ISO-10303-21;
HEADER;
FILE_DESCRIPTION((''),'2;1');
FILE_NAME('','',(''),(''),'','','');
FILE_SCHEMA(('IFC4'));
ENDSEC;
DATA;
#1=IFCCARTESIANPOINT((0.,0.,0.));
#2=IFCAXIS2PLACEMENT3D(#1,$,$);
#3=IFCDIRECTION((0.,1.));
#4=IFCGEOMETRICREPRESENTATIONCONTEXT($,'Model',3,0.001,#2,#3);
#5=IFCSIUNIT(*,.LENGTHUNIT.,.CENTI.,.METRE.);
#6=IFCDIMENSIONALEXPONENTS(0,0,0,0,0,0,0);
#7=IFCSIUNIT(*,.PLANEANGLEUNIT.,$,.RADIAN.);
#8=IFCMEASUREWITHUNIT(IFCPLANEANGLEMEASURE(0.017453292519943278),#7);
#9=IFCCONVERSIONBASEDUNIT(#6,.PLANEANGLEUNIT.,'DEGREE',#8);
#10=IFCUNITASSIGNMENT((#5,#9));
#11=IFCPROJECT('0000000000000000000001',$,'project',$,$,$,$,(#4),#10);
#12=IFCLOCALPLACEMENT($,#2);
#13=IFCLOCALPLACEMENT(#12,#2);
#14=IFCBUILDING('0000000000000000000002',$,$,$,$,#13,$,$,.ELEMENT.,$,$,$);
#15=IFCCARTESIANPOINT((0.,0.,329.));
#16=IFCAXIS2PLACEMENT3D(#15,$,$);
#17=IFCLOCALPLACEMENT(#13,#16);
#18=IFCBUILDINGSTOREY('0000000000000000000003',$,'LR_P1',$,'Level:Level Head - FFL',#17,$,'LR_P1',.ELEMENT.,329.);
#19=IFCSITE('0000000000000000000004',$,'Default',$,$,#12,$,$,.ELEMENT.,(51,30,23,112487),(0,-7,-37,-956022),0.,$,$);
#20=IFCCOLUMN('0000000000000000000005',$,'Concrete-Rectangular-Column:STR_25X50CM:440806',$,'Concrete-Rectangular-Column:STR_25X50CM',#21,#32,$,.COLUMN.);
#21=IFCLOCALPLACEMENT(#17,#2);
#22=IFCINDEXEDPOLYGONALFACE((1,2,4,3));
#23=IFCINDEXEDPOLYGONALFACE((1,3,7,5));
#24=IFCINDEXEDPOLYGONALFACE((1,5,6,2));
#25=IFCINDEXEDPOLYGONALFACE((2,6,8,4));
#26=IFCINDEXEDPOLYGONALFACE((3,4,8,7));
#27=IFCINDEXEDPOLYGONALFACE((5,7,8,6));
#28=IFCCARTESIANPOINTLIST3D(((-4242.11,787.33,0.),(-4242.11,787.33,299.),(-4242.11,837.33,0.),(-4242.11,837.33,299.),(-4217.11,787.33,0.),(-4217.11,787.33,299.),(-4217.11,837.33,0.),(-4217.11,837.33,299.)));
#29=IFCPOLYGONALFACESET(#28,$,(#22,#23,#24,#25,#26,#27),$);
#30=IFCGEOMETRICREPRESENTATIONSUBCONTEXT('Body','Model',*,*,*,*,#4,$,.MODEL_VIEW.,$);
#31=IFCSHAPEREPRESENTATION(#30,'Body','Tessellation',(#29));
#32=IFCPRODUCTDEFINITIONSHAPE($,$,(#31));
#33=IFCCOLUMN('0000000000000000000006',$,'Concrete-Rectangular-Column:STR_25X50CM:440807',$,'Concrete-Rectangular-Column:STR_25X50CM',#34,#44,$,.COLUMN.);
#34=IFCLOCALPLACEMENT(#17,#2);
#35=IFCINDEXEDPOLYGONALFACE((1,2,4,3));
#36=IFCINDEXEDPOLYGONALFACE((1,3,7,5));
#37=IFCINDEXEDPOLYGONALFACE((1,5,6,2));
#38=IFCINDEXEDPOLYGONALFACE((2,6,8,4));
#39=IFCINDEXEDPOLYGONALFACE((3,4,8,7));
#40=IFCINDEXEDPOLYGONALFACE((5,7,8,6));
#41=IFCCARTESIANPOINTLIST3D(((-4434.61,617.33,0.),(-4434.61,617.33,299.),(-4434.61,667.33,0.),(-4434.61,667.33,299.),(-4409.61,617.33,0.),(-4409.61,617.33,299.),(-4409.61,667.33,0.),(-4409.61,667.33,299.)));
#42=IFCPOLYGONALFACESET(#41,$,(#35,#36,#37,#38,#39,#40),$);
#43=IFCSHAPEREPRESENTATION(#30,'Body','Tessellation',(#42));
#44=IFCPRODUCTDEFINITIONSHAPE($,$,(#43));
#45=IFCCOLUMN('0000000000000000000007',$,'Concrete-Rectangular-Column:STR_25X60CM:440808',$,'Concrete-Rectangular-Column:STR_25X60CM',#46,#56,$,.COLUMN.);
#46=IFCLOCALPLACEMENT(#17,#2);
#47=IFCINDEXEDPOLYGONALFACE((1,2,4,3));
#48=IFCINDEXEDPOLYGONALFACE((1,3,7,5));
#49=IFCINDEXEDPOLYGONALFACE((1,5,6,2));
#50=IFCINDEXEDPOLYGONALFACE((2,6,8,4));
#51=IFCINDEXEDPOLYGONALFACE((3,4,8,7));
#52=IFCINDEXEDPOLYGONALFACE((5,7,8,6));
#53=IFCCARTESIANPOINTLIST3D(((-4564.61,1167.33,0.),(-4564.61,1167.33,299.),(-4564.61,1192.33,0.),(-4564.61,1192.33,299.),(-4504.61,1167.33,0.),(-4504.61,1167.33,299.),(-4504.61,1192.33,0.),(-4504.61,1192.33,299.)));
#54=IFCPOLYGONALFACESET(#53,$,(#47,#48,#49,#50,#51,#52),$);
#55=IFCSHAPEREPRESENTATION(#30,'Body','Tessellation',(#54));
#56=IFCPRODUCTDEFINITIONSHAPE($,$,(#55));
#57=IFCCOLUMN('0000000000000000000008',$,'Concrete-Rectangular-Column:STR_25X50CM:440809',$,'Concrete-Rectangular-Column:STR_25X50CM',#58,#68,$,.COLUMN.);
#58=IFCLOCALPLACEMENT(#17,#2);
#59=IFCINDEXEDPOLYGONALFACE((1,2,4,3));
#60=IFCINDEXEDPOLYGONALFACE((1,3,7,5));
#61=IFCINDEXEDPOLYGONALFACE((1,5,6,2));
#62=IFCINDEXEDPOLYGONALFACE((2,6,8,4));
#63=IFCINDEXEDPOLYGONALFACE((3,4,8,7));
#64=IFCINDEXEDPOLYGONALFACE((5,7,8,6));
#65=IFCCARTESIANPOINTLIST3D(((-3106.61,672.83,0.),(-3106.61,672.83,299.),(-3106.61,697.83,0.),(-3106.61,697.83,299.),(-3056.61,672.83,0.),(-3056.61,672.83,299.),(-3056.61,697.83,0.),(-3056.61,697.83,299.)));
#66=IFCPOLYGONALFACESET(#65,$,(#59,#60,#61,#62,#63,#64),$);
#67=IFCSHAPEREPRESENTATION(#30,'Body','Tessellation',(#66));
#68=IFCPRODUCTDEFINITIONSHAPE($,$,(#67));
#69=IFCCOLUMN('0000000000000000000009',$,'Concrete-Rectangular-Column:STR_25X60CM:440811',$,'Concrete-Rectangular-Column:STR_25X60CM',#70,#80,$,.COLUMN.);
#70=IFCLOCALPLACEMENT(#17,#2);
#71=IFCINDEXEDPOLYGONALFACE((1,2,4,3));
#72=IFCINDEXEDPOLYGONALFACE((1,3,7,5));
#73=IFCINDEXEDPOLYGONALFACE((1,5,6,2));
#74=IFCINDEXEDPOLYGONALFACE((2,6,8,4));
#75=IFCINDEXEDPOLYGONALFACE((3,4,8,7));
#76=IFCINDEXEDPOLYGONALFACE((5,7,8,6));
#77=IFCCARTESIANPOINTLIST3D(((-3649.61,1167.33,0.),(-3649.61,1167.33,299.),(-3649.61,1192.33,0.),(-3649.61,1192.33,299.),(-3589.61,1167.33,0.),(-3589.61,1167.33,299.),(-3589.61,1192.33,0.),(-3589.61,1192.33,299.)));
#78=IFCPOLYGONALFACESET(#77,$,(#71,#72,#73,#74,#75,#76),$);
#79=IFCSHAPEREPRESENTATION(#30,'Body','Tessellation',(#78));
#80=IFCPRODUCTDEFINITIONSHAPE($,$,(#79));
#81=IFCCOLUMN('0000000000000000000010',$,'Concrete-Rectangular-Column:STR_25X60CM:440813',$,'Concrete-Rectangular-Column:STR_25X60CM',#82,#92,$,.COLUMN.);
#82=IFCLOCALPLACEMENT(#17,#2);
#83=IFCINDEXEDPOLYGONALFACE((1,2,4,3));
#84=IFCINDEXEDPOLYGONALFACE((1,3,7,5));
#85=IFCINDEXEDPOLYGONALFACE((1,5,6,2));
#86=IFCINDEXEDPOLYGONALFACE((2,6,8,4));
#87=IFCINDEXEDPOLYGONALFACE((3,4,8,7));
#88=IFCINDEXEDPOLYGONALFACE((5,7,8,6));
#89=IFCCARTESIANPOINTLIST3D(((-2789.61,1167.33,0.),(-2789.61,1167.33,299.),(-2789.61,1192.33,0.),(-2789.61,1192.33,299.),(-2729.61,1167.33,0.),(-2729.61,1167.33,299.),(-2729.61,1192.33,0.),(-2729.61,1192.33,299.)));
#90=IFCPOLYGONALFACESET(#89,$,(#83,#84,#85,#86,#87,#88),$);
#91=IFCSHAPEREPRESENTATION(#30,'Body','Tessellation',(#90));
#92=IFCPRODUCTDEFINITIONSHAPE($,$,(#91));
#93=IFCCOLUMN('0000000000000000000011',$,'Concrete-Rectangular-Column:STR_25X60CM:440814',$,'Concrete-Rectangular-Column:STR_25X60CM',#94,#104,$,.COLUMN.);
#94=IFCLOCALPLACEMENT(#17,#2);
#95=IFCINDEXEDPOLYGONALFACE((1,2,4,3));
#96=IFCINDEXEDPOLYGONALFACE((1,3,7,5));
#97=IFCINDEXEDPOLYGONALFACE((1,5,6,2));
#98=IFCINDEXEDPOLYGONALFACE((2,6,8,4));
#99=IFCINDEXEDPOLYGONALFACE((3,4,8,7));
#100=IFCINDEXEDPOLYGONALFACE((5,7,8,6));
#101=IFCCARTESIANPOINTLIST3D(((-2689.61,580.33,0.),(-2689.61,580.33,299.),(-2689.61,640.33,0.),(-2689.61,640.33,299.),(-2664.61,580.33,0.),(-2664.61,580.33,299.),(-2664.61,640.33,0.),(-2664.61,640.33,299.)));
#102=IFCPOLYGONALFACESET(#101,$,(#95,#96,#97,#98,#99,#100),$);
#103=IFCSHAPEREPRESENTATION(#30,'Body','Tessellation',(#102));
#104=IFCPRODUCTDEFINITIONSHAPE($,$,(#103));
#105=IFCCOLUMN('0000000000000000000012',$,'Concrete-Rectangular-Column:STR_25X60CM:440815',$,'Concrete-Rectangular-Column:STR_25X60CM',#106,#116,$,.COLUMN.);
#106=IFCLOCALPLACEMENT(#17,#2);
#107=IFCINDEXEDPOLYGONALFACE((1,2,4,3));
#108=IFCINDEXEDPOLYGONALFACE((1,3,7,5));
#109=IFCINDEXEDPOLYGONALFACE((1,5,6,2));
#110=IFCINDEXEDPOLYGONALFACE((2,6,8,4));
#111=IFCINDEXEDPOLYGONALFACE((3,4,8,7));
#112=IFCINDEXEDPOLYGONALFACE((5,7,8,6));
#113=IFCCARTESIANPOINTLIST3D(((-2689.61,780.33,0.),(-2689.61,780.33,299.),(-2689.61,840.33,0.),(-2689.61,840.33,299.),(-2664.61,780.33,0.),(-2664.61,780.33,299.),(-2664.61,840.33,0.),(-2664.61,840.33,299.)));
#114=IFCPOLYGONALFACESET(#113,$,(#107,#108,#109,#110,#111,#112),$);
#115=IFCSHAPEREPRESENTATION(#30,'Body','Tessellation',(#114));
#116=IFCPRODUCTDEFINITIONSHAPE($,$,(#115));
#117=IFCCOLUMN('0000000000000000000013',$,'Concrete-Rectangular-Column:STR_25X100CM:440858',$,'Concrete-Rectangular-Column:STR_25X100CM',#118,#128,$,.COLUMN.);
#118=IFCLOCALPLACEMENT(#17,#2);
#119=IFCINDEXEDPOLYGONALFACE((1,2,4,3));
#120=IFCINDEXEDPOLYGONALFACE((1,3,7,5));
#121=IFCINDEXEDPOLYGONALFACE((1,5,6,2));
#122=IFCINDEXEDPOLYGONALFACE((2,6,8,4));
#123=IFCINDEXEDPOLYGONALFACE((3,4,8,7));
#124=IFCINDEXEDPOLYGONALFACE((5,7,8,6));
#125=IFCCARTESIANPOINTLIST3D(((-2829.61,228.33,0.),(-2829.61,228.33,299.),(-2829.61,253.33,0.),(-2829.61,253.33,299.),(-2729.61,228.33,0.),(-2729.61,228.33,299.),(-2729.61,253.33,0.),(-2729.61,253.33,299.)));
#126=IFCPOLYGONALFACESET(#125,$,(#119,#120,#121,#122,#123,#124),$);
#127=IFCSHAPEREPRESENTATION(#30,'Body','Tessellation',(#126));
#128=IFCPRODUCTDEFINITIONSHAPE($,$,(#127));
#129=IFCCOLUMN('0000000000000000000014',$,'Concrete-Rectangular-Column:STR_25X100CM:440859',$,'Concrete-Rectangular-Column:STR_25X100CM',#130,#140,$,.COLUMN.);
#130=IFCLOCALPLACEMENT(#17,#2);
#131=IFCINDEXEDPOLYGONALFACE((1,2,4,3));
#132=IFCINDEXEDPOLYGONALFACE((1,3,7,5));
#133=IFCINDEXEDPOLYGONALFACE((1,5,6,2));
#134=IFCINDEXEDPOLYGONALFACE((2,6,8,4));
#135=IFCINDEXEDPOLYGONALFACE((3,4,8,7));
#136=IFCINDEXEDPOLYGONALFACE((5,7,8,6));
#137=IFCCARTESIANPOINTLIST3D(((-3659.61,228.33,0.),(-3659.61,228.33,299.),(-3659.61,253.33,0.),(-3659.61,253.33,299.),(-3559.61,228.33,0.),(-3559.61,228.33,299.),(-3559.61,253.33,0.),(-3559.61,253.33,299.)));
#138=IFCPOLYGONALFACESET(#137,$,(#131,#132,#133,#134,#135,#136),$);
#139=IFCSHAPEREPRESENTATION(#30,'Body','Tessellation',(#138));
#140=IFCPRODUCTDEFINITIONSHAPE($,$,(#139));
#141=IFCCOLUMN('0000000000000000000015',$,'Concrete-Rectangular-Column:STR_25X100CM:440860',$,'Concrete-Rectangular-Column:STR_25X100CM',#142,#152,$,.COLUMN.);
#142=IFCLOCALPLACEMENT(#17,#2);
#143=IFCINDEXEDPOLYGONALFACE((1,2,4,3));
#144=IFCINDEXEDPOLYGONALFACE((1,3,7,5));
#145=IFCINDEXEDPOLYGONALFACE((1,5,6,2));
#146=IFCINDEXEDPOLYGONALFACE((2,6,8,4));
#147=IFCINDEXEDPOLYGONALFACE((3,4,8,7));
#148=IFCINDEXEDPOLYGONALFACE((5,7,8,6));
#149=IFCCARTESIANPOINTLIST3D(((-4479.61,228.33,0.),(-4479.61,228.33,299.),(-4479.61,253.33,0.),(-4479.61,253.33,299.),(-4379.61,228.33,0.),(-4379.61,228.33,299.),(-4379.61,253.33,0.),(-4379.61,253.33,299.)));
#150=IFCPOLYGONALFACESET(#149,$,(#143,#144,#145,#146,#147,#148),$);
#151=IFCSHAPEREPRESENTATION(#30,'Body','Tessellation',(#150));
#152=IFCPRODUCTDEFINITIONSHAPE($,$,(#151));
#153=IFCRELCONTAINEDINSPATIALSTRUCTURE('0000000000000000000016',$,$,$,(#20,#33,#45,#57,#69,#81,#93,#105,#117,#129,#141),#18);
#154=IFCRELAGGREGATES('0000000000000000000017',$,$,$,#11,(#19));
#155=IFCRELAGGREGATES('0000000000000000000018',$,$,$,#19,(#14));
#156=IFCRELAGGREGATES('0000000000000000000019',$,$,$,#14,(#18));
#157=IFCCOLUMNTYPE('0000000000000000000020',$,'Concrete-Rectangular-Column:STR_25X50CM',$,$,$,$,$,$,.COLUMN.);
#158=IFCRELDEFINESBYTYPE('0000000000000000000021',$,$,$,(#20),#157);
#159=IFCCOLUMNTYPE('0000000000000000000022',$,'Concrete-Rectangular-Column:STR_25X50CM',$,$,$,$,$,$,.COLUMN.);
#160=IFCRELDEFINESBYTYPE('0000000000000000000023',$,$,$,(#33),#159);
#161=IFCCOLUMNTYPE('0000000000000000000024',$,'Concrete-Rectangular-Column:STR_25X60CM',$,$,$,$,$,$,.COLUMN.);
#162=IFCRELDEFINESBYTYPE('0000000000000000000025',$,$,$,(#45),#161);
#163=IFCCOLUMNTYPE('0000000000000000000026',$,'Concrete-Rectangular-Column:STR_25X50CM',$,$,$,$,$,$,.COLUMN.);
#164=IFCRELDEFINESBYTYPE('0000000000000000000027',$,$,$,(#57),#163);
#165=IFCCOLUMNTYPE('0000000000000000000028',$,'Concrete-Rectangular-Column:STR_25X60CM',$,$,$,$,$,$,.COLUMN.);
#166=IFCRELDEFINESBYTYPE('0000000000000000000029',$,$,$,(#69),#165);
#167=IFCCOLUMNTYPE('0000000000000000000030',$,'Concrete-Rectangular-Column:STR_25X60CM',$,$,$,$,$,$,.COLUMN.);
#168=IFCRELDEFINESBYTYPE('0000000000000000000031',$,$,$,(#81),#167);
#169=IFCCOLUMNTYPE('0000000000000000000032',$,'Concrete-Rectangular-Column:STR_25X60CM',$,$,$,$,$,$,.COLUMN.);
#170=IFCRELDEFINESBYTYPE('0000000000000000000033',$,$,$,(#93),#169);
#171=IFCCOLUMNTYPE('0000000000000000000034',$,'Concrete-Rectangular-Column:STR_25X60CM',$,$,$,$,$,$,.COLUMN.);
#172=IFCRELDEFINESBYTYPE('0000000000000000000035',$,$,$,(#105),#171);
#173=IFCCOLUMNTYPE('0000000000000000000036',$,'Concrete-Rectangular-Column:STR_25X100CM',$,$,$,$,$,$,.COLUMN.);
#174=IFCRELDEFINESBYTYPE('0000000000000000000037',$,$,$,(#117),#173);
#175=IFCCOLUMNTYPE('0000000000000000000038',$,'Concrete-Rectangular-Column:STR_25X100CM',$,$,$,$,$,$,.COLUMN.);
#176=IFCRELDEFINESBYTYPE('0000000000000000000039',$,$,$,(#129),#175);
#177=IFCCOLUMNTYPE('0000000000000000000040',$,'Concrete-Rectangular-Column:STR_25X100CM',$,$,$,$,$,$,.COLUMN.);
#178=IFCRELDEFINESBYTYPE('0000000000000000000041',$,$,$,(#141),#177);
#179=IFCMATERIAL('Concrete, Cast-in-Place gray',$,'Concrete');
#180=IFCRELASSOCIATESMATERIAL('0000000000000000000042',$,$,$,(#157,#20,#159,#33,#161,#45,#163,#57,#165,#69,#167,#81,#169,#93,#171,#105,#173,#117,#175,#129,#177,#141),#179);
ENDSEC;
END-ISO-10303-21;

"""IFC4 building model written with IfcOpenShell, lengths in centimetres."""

from ifc_helpers import new_model, entity, si_unit, converted_unit, direction, frame, origin, place, context, subcontext, project, spatial, indexed_curve, outline, extrude, source, transform, mapped, material, type_object, type_shapes, element, save


model = new_model("IFC4")

# Units and contexts
model_context = context("Model", 3, precision=0.001, world=origin(), true_north=direction((0.0, 1.0)))
body_context = subcontext(model_context, "Body", "Model", "MODEL_VIEW")
ifc_project = project(units=[si_unit("LENGTHUNIT", "METRE", prefix="CENTI"), converted_unit("PLANEANGLEUNIT", "DEGREE", entity("IfcPlaneAngleMeasure", 0.017453292519943278), si_unit("PLANEANGLEUNIT", "RADIAN"), dimensions=[0, 0, 0, 0, 0, 0, 0])], contexts=[model_context])

# Site, building, storey
site_placement = place(None, origin())
site = spatial("IfcSite", under=ifc_project, at=site_placement, Name="Default", CompositionType="ELEMENT", RefLatitude=(51, 30, 23, 112487), RefLongitude=(0, -7, -37, -956022), RefElevation=0.0)
building_placement = place(site_placement, origin())
building = spatial("IfcBuilding", under=site, at=building_placement, CompositionType="ELEMENT")
storey_placement = place(building_placement, frame((0.0, 0.0, 329.0)))
storey = spatial("IfcBuildingStorey", under=building, at=storey_placement, Name="LR_P1", ObjectType="Level:Level Head - FFL", LongName="LR_P1", CompositionType="ELEMENT", Elevation=329.0)

# Columns
ifc_material_1 = material(Name="Concrete, Cast-in-Place gray", Category="Concrete")
column_type_1 = type_object("IfcColumnType", Name="Concrete-Rectangular-Column:STR_25X50CM", PredefinedType="COLUMN", material=ifc_material_1)
shared_shape_1 = source(origin(), body_context, "Body", "SweptSolid", [
    extrude(outline(indexed_curve([(-12.5, -25.0), (12.5, -25.0), (12.5, 25.0), (-12.5, 25.0), (-12.5, -25.0)], self_intersect=False)), frame((-4229.61, 812.33, 329.0), z_axis=(0.0, 0.0, 1.0), x_axis=(-1.0, 0.0, 0.0)), (0.0, 0.0, 1.0), 299.0),
])
type_shapes(column_type_1, [shared_shape_1])
column_1_placement = place(storey_placement, frame((0.0, 0.0, -329.0)))
element("IfcColumn", 1, at=column_1_placement, inside=storey, type_object=column_type_1, material=ifc_material_1, Name="Concrete-Rectangular-Column:STR_25X50CM:440806", ObjectType="Concrete-Rectangular-Column:STR_25X50CM", PredefinedType="COLUMN", context=body_context, shape_type="MappedRepresentation", body=[
    mapped(shared_shape_1, transform((0.0, 0.0, 0.0), scale=1.0)),
])
column_type_2 = type_object("IfcColumnType", Name="Concrete-Rectangular-Column:STR_25X50CM", PredefinedType="COLUMN", material=ifc_material_1)
shared_shape_2 = source(origin(), body_context, "Body", "SweptSolid", [
    extrude(outline(indexed_curve([(-12.5, -25.0), (12.5, -25.0), (12.5, 25.0), (-12.5, 25.0), (-12.5, -25.0)], self_intersect=False)), frame((-4422.11, 642.33, 329.0), z_axis=(0.0, 0.0, 1.0), x_axis=(-1.0, 0.0, 0.0)), (0.0, 0.0, 1.0), 299.0),
])
type_shapes(column_type_2, [shared_shape_2])
column_2_placement = place(storey_placement, frame((0.0, 0.0, -329.0)))
element("IfcColumn", 2, at=column_2_placement, inside=storey, type_object=column_type_2, material=ifc_material_1, Name="Concrete-Rectangular-Column:STR_25X50CM:440807", ObjectType="Concrete-Rectangular-Column:STR_25X50CM", PredefinedType="COLUMN", context=body_context, shape_type="MappedRepresentation", body=[
    mapped(shared_shape_2, transform((0.0, 0.0, 0.0), scale=1.0)),
])
column_type_3 = type_object("IfcColumnType", Name="Concrete-Rectangular-Column:STR_25X60CM", PredefinedType="COLUMN", material=ifc_material_1)
shared_shape_3 = source(origin(), body_context, "Body", "SweptSolid", [
    extrude(outline(indexed_curve([(-12.5, -30.0), (12.5, -30.0), (12.5, 30.0), (-12.5, 30.0), (-12.5, -30.0)], self_intersect=False)), frame((-4534.61, 1179.83, 329.0), z_axis=(0.0, 0.0, 1.0), x_axis=(0.0, -1.0, 0.0)), (0.0, 0.0, 1.0), 299.0),
])
type_shapes(column_type_3, [shared_shape_3])
column_3_placement = place(storey_placement, frame((0.0, 0.0, -329.0)))
element("IfcColumn", 3, at=column_3_placement, inside=storey, type_object=column_type_3, material=ifc_material_1, Name="Concrete-Rectangular-Column:STR_25X60CM:440808", ObjectType="Concrete-Rectangular-Column:STR_25X60CM", PredefinedType="COLUMN", context=body_context, shape_type="MappedRepresentation", body=[
    mapped(shared_shape_3, transform((0.0, 0.0, 0.0), scale=1.0)),
])
column_type_4 = type_object("IfcColumnType", Name="Concrete-Rectangular-Column:STR_25X50CM", PredefinedType="COLUMN", material=ifc_material_1)
shared_shape_4 = source(origin(), body_context, "Body", "SweptSolid", [
    extrude(outline(indexed_curve([(-12.5, -25.0), (12.5, -25.0), (12.5, 25.0), (-12.5, 25.0), (-12.5, -25.0)], self_intersect=False)), frame((-3081.61, 685.33, 329.0), z_axis=(0.0, 0.0, 1.0), x_axis=(0.0, -1.0, 0.0)), (0.0, 0.0, 1.0), 299.0),
])
type_shapes(column_type_4, [shared_shape_4])
column_4_placement = place(storey_placement, frame((0.0, 0.0, -329.0)))
element("IfcColumn", 4, at=column_4_placement, inside=storey, type_object=column_type_4, material=ifc_material_1, Name="Concrete-Rectangular-Column:STR_25X50CM:440809", ObjectType="Concrete-Rectangular-Column:STR_25X50CM", PredefinedType="COLUMN", context=body_context, shape_type="MappedRepresentation", body=[
    mapped(shared_shape_4, transform((0.0, 0.0, 0.0), scale=1.0)),
])
column_type_5 = type_object("IfcColumnType", Name="Concrete-Rectangular-Column:STR_25X60CM", PredefinedType="COLUMN", material=ifc_material_1)
shared_shape_5 = source(origin(), body_context, "Body", "SweptSolid", [
    extrude(outline(indexed_curve([(-12.5, -30.0), (12.5, -30.0), (12.5, 30.0), (-12.5, 30.0), (-12.5, -30.0)], self_intersect=False)), frame((-3619.61, 1179.83, 329.0), z_axis=(0.0, 0.0, 1.0), x_axis=(0.0, -1.0, 0.0)), (0.0, 0.0, 1.0), 299.0),
])
type_shapes(column_type_5, [shared_shape_5])
column_5_placement = place(storey_placement, frame((0.0, 0.0, -329.0)))
element("IfcColumn", 5, at=column_5_placement, inside=storey, type_object=column_type_5, material=ifc_material_1, Name="Concrete-Rectangular-Column:STR_25X60CM:440811", ObjectType="Concrete-Rectangular-Column:STR_25X60CM", PredefinedType="COLUMN", context=body_context, shape_type="MappedRepresentation", body=[
    mapped(shared_shape_5, transform((0.0, 0.0, 0.0), scale=1.0)),
])
column_type_6 = type_object("IfcColumnType", Name="Concrete-Rectangular-Column:STR_25X60CM", PredefinedType="COLUMN", material=ifc_material_1)
shared_shape_6 = source(origin(), body_context, "Body", "SweptSolid", [
    extrude(outline(indexed_curve([(-12.5, -30.0), (12.5, -30.0), (12.5, 30.0), (-12.5, 30.0), (-12.5, -30.0)], self_intersect=False)), frame((-2759.61, 1179.83, 329.0), z_axis=(0.0, 0.0, 1.0), x_axis=(0.0, -1.0, 0.0)), (0.0, 0.0, 1.0), 299.0),
])
type_shapes(column_type_6, [shared_shape_6])
column_6_placement = place(storey_placement, frame((0.0, 0.0, -329.0)))
element("IfcColumn", 6, at=column_6_placement, inside=storey, type_object=column_type_6, material=ifc_material_1, Name="Concrete-Rectangular-Column:STR_25X60CM:440813", ObjectType="Concrete-Rectangular-Column:STR_25X60CM", PredefinedType="COLUMN", context=body_context, shape_type="MappedRepresentation", body=[
    mapped(shared_shape_6, transform((0.0, 0.0, 0.0), scale=1.0)),
])
column_type_7 = type_object("IfcColumnType", Name="Concrete-Rectangular-Column:STR_25X60CM", PredefinedType="COLUMN", material=ifc_material_1)
shared_shape_7 = source(origin(), body_context, "Body", "SweptSolid", [
    extrude(outline(indexed_curve([(-12.5, -30.0), (12.5, -30.0), (12.5, 30.0), (-12.5, 30.0), (-12.5, -30.0)], self_intersect=False)), frame((-2677.11, 610.33, 329.0), z_axis=(0.0, 0.0, 1.0), x_axis=(-1.0, 0.0, 0.0)), (0.0, 0.0, 1.0), 299.0),
])
type_shapes(column_type_7, [shared_shape_7])
column_7_placement = place(storey_placement, frame((0.0, 0.0, -329.0)))
element("IfcColumn", 7, at=column_7_placement, inside=storey, type_object=column_type_7, material=ifc_material_1, Name="Concrete-Rectangular-Column:STR_25X60CM:440814", ObjectType="Concrete-Rectangular-Column:STR_25X60CM", PredefinedType="COLUMN", context=body_context, shape_type="MappedRepresentation", body=[
    mapped(shared_shape_7, transform((0.0, 0.0, 0.0), scale=1.0)),
])
column_type_8 = type_object("IfcColumnType", Name="Concrete-Rectangular-Column:STR_25X60CM", PredefinedType="COLUMN", material=ifc_material_1)
shared_shape_8 = source(origin(), body_context, "Body", "SweptSolid", [
    extrude(outline(indexed_curve([(-12.5, -30.0), (12.5, -30.0), (12.5, 30.0), (-12.5, 30.0), (-12.5, -30.0)], self_intersect=False)), frame((-2677.11, 810.33, 329.0), z_axis=(0.0, 0.0, 1.0), x_axis=(-1.0, 0.0, 0.0)), (0.0, 0.0, 1.0), 299.0),
])
type_shapes(column_type_8, [shared_shape_8])
column_8_placement = place(storey_placement, frame((0.0, 0.0, -329.0)))
element("IfcColumn", 8, at=column_8_placement, inside=storey, type_object=column_type_8, material=ifc_material_1, Name="Concrete-Rectangular-Column:STR_25X60CM:440815", ObjectType="Concrete-Rectangular-Column:STR_25X60CM", PredefinedType="COLUMN", context=body_context, shape_type="MappedRepresentation", body=[
    mapped(shared_shape_8, transform((0.0, 0.0, 0.0), scale=1.0)),
])
column_type_9 = type_object("IfcColumnType", Name="Concrete-Rectangular-Column:STR_25X100CM", PredefinedType="COLUMN", material=ifc_material_1)
shared_shape_9 = source(origin(), body_context, "Body", "SweptSolid", [
    extrude(outline(indexed_curve([(-12.5, -50.0), (12.5, -50.0), (12.5, 50.0), (-12.5, 50.0), (-12.5, -50.0)], self_intersect=False)), frame((-2779.61, 240.83, 329.0), z_axis=(0.0, 0.0, 1.0), x_axis=(0.0, -1.0, 0.0)), (0.0, 0.0, 1.0), 299.0),
])
type_shapes(column_type_9, [shared_shape_9])
column_9_placement = place(storey_placement, frame((0.0, 0.0, -329.0)))
element("IfcColumn", 9, at=column_9_placement, inside=storey, type_object=column_type_9, material=ifc_material_1, Name="Concrete-Rectangular-Column:STR_25X100CM:440858", ObjectType="Concrete-Rectangular-Column:STR_25X100CM", PredefinedType="COLUMN", context=body_context, shape_type="MappedRepresentation", body=[
    mapped(shared_shape_9, transform((0.0, 0.0, 0.0), scale=1.0)),
])
column_type_10 = type_object("IfcColumnType", Name="Concrete-Rectangular-Column:STR_25X100CM", PredefinedType="COLUMN", material=ifc_material_1)
shared_shape_10 = source(origin(), body_context, "Body", "SweptSolid", [
    extrude(outline(indexed_curve([(-12.5, -50.0), (12.5, -50.0), (12.5, 50.0), (-12.5, 50.0), (-12.5, -50.0)], self_intersect=False)), frame((-3609.61, 240.83, 329.0), z_axis=(0.0, 0.0, 1.0), x_axis=(0.0, -1.0, 0.0)), (0.0, 0.0, 1.0), 299.0),
])
type_shapes(column_type_10, [shared_shape_10])
column_10_placement = place(storey_placement, frame((0.0, 0.0, -329.0)))
element("IfcColumn", 10, at=column_10_placement, inside=storey, type_object=column_type_10, material=ifc_material_1, Name="Concrete-Rectangular-Column:STR_25X100CM:440859", ObjectType="Concrete-Rectangular-Column:STR_25X100CM", PredefinedType="COLUMN", context=body_context, shape_type="MappedRepresentation", body=[
    mapped(shared_shape_10, transform((0.0, 0.0, 0.0), scale=1.0)),
])
column_type_11 = type_object("IfcColumnType", Name="Concrete-Rectangular-Column:STR_25X100CM", PredefinedType="COLUMN", material=ifc_material_1)
shared_shape_11 = source(origin(), body_context, "Body", "SweptSolid", [
    extrude(outline(indexed_curve([(-12.5, -50.0), (12.5, -50.0), (12.5, 50.0), (-12.5, 50.0), (-12.5, -50.0)], self_intersect=False)), frame((-4429.61, 240.83, 329.0), z_axis=(0.0, 0.0, 1.0), x_axis=(0.0, -1.0, 0.0)), (0.0, 0.0, 1.0), 299.0),
])
type_shapes(column_type_11, [shared_shape_11])
column_11_placement = place(storey_placement, frame((0.0, 0.0, -329.0)))
element("IfcColumn", 11, at=column_11_placement, inside=storey, type_object=column_type_11, material=ifc_material_1, Name="Concrete-Rectangular-Column:STR_25X100CM:440860", ObjectType="Concrete-Rectangular-Column:STR_25X100CM", PredefinedType="COLUMN", context=body_context, shape_type="MappedRepresentation", body=[
    mapped(shared_shape_11, transform((0.0, 0.0, 0.0), scale=1.0)),
])

save(model, "model.ifc")
